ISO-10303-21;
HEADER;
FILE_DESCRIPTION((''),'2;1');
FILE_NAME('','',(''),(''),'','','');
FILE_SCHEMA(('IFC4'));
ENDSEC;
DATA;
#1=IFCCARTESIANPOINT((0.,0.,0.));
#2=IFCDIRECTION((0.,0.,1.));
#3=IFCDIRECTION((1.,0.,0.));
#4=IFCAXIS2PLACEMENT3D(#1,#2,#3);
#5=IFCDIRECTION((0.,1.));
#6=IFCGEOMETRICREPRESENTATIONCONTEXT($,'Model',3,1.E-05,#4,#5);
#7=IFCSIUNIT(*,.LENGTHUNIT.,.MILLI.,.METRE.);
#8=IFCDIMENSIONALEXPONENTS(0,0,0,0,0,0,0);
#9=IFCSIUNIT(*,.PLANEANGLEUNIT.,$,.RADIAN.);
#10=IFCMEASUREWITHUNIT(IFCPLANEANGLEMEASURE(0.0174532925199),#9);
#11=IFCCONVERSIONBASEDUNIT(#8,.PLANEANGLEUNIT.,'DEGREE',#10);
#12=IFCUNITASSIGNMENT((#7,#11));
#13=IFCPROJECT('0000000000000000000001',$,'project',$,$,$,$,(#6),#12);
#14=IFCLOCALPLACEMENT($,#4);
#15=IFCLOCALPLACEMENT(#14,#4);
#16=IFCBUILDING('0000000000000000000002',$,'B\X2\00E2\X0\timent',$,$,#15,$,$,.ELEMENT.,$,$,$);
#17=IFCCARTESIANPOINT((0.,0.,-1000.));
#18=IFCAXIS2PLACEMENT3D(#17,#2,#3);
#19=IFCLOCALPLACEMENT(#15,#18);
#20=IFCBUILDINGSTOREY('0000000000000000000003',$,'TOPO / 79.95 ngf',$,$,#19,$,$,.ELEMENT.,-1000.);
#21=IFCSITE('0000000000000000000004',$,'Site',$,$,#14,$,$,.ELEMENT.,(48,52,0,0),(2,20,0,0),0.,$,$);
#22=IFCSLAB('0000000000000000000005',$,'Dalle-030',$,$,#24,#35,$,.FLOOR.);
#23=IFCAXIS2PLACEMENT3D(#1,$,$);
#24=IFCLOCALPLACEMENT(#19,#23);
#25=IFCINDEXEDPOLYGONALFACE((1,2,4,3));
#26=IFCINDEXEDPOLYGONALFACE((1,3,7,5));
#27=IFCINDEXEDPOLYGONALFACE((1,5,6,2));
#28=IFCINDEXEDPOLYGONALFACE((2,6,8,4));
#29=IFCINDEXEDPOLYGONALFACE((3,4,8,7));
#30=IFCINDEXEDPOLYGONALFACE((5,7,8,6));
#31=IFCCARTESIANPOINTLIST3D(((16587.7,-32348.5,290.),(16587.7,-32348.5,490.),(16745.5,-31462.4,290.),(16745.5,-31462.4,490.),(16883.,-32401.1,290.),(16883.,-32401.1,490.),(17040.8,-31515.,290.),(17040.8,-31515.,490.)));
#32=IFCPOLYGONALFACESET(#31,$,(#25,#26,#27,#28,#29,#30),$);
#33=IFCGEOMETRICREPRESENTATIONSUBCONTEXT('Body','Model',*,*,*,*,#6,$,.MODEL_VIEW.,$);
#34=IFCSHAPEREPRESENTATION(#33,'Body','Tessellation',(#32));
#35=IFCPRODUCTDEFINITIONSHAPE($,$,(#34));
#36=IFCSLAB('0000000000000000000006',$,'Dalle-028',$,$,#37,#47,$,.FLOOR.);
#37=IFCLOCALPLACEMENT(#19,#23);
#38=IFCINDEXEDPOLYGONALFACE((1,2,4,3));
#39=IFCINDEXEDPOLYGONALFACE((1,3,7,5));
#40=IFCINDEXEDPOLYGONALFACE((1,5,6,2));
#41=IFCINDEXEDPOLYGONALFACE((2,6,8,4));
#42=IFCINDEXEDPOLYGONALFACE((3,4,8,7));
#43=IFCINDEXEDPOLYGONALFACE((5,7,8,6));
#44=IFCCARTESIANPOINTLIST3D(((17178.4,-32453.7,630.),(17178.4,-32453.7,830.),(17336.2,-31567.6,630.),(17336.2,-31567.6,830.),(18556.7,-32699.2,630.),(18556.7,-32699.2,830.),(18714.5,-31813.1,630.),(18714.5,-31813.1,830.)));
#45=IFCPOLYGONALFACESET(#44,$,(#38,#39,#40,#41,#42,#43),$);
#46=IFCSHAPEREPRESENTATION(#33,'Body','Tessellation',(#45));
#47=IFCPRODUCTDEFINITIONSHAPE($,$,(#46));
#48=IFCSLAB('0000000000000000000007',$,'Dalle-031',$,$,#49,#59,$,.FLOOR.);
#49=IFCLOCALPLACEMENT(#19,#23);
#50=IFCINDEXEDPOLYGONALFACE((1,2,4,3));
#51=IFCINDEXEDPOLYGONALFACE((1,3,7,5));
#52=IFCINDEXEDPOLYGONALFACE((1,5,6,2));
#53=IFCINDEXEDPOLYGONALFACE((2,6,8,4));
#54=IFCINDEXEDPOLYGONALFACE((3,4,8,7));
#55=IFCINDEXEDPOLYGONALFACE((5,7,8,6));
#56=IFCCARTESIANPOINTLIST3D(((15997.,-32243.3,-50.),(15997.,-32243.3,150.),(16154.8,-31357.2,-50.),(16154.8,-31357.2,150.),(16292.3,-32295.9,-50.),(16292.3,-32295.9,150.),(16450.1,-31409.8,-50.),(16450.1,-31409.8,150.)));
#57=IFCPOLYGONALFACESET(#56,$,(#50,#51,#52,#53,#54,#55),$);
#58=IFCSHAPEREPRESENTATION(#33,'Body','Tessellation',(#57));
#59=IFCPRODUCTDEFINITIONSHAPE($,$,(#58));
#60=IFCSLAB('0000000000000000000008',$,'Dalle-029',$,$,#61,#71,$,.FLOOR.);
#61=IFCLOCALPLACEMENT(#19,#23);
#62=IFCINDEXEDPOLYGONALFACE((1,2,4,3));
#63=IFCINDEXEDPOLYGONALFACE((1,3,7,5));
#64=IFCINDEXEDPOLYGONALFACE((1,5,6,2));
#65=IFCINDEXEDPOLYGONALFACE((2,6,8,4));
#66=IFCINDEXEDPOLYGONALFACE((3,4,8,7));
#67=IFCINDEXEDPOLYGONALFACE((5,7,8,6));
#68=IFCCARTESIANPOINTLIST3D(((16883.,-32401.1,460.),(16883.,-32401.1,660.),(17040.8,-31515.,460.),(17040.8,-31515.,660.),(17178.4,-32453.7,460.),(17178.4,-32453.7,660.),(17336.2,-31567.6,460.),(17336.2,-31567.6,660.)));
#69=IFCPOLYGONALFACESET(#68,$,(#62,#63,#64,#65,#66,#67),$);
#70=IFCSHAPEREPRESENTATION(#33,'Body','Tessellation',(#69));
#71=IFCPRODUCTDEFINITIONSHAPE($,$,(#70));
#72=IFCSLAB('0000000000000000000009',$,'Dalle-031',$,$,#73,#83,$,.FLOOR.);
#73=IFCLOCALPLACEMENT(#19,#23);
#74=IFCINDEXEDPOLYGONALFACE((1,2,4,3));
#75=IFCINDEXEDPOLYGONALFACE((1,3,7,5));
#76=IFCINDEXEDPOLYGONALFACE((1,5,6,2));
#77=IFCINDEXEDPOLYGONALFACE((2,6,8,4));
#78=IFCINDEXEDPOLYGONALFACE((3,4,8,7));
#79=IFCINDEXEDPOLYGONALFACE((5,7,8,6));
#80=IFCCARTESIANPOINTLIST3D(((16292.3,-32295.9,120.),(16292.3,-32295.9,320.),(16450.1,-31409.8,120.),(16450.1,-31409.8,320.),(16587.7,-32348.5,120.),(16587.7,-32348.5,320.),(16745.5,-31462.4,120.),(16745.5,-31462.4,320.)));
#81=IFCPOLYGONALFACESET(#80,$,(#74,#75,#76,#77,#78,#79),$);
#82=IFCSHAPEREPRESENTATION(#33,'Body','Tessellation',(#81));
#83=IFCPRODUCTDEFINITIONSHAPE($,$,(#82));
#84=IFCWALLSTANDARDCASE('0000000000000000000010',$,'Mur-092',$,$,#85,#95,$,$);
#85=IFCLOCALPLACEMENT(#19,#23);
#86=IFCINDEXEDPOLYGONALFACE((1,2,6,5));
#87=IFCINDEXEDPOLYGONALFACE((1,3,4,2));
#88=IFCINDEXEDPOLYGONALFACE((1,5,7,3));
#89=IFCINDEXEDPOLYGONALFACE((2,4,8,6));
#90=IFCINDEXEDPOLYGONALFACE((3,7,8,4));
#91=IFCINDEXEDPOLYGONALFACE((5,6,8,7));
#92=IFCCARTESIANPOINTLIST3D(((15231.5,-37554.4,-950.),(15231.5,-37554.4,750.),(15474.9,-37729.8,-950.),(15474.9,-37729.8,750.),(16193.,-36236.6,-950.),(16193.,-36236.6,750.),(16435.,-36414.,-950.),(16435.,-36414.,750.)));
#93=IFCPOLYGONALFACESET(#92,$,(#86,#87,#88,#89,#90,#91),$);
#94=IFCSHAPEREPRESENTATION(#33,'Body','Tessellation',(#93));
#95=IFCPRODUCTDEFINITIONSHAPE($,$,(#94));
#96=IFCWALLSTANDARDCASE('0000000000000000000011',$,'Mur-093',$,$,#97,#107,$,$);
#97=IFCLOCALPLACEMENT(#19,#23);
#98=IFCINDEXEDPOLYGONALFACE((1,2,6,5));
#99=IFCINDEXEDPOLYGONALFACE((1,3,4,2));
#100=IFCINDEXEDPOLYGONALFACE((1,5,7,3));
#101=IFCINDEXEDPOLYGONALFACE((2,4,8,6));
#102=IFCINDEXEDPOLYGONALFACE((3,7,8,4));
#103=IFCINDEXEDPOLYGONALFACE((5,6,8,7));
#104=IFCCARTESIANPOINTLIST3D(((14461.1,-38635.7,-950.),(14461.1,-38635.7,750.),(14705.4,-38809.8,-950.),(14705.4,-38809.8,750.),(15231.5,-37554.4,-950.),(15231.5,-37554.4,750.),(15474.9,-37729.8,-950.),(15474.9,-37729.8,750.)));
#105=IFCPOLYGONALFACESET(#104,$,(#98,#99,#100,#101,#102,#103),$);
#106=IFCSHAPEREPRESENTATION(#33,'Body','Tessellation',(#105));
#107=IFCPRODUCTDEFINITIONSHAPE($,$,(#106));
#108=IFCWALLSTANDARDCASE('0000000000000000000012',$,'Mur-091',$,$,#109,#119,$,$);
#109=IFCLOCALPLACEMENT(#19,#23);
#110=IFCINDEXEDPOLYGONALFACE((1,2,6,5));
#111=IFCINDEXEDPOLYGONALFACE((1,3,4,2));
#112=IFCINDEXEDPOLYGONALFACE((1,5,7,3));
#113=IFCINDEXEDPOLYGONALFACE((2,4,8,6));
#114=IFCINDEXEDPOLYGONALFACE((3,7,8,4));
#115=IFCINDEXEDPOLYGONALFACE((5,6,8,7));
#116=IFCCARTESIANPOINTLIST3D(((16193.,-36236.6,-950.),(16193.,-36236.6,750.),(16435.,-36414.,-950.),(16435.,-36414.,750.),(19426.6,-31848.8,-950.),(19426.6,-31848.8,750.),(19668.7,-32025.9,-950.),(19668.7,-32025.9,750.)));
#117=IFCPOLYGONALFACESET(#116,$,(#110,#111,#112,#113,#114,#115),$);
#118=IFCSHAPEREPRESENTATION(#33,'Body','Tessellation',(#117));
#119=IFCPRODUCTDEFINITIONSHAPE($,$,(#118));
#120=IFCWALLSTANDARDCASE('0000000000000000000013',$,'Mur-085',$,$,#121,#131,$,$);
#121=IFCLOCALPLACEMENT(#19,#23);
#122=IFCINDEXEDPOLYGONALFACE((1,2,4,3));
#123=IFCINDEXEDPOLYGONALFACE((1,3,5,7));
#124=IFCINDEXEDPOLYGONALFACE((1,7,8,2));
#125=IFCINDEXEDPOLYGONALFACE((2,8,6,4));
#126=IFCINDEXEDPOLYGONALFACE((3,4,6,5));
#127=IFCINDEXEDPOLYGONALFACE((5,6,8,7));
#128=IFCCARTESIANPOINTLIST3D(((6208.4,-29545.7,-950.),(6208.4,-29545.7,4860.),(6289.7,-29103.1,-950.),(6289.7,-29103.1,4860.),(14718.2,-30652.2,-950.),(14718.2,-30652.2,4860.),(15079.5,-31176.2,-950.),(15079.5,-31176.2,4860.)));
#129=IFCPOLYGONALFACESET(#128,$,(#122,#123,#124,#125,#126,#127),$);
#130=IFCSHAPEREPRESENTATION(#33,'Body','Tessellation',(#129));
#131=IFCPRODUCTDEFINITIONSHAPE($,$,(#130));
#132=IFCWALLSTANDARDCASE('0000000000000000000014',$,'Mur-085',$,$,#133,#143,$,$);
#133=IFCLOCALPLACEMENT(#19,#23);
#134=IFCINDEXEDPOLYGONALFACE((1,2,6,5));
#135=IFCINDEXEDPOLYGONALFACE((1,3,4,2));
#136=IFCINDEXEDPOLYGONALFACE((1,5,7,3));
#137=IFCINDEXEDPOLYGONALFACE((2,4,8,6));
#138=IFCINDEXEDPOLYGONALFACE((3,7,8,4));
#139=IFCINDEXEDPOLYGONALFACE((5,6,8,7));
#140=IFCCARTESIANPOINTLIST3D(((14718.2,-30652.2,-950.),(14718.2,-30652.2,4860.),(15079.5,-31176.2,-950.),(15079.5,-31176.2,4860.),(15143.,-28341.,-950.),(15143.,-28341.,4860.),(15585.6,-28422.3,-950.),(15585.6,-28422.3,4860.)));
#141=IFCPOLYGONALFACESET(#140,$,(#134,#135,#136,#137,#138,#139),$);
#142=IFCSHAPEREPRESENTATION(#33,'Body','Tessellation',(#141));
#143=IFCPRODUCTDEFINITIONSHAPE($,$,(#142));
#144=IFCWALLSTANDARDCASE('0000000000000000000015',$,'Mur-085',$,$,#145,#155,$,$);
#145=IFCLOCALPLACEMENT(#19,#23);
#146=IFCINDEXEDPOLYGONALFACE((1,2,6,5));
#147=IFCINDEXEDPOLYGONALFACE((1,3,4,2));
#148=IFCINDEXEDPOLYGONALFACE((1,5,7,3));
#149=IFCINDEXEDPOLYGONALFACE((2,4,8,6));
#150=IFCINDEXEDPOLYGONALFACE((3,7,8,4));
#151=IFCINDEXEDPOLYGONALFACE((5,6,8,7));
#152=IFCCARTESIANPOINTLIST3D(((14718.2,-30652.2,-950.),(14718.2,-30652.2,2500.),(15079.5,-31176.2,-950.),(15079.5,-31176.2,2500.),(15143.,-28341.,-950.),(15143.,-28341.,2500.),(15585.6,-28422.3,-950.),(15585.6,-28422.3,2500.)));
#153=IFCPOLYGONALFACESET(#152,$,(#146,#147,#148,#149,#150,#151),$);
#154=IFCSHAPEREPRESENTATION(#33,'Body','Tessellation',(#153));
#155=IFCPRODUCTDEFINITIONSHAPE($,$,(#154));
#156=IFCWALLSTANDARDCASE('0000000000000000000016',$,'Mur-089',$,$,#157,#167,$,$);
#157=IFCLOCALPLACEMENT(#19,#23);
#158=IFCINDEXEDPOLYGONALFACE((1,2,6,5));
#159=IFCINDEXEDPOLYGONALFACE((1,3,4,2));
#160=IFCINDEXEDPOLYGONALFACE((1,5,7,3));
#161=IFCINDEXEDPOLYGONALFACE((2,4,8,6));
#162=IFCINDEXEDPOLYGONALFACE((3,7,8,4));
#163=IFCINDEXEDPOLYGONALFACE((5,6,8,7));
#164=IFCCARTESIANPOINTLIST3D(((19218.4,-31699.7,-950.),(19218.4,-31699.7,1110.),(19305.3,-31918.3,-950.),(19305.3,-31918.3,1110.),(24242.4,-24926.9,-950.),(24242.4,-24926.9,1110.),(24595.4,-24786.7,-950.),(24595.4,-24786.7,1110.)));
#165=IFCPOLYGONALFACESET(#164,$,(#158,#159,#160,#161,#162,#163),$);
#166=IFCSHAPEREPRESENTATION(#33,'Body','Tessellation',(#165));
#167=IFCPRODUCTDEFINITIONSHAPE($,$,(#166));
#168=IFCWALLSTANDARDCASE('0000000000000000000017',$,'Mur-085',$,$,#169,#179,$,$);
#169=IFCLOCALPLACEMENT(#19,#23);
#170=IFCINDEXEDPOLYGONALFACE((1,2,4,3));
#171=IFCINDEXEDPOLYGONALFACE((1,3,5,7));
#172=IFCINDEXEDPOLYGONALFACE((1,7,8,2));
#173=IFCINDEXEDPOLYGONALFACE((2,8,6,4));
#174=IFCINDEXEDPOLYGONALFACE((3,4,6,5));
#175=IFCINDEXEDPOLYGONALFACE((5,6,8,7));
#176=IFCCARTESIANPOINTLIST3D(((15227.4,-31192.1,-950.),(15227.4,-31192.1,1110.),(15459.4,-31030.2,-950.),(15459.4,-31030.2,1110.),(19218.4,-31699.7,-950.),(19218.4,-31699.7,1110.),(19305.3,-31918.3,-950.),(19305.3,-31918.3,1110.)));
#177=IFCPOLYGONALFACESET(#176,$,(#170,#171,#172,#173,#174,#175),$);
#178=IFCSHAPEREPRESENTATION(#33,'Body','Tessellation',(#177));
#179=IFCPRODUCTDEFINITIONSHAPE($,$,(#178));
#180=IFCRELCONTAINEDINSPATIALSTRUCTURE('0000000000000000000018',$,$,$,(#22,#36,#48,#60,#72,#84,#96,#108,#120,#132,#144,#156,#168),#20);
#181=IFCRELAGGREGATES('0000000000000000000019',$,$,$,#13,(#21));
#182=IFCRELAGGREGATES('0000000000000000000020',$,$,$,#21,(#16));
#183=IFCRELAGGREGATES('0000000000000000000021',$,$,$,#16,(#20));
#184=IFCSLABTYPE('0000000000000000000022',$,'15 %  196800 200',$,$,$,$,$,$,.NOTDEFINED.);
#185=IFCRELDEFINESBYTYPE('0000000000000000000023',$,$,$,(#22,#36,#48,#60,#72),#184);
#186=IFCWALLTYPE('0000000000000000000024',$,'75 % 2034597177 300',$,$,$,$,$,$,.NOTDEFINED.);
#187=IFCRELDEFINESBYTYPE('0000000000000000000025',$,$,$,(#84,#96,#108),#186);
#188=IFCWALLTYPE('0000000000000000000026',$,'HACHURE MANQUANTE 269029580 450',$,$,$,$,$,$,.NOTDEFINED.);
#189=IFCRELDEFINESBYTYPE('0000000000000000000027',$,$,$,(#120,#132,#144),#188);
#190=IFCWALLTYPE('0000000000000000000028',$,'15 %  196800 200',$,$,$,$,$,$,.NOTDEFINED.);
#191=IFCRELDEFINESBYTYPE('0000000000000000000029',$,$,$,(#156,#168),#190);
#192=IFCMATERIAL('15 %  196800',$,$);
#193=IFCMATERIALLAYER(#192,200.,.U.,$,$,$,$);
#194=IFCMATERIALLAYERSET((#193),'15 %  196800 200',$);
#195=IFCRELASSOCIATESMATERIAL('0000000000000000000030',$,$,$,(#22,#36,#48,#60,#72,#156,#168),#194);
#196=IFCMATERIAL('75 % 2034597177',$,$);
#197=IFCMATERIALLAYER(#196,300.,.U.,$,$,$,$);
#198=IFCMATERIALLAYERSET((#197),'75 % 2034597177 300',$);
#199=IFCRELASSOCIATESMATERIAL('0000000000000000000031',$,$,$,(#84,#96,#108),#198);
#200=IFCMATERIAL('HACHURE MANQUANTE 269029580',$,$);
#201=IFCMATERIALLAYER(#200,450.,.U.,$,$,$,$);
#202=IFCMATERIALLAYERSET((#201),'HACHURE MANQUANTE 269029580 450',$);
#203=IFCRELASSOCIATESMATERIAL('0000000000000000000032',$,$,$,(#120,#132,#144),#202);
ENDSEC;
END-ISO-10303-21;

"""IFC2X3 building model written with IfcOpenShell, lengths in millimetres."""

from ifc_helpers import new_model, entity, si_unit, converted_unit, direction, frame, origin_with_axes, place, context, subcontext, project, spatial, polyline, outline, extrude, material, layer, layer_set, layer_usage, type_object, element, save


model = new_model("IFC2X3")

# Units and contexts
model_context = context("Model", 3, precision=1e-05, world=origin_with_axes(), true_north=direction((0.0, 1.0)))
body_context = subcontext(model_context, "Body", "Model", "MODEL_VIEW")
ifc_project = project(units=[si_unit("LENGTHUNIT", "METRE", prefix="MILLI"), converted_unit("PLANEANGLEUNIT", "DEGREE", entity("IfcPlaneAngleMeasure", 0.0174532925199), si_unit("PLANEANGLEUNIT", "RADIAN"), dimensions=[0, 0, 0, 0, 0, 0, 0])], contexts=[model_context])

# Site, building, storey
site_placement = place(None, origin_with_axes())
site = spatial("IfcSite", under=ifc_project, at=site_placement, Name="Site", CompositionType="ELEMENT", RefLatitude=(48, 52, 0, 0), RefLongitude=(2, 20, 0, 0), RefElevation=0.0)
building_placement = place(site_placement, origin_with_axes())
building = spatial("IfcBuilding", under=site, at=building_placement, Name="Bâtiment", CompositionType="ELEMENT")
storey_placement = place(building_placement, frame((0.0, 0.0, -1000.0), z_axis=(0.0, 0.0, 1.0), x_axis=(1.0, 0.0, 0.0)))
storey = spatial("IfcBuildingStorey", under=building, at=storey_placement, Name="TOPO / 79.95 ngf", CompositionType="ELEMENT", Elevation=-1000.0)

# Slabs
ifc_material_1 = material(Name="15 %  196800")
ifc_layer_1 = layer(ifc_material_1, 200.0, ventilated="UNKNOWN")
ifc_layer_set_1 = layer_set([ifc_layer_1], Name="15 %  196800 200")
ifc_layer_usage_1 = layer_usage(ifc_layer_set_1, "AXIS3", "NEGATIVE", 200.0)
slab_type_1 = type_object("IfcSlabType", Name="15 %  196800 200", PredefinedType="NOTDEFINED")
slab_1_placement = place(storey_placement, frame((16745.5, -31462.4, 490.0), z_axis=(0.0, 0.0, 1.0), x_axis=(1.0, 0.0, 0.0)))
element("IfcSlab", 1, at=slab_1_placement, inside=storey, type_object=slab_type_1, material=ifc_layer_usage_1, Name="Dalle-030", PredefinedType="FLOOR", context=body_context, shape_type="SweptSolid", body=[
    extrude(outline(polyline([(0.0, 0.0), (-157.8, -886.1), (137.5, -938.7), (295.4, -52.6), (0.0, 0.0)])), frame((0.0, 0.0, -200.0), z_axis=(0.0, 0.0, 1.0), x_axis=(1.0, 0.0, 0.0)), (0.0, 0.0, 1.0), 200.0),
])
ifc_layer_usage_2 = layer_usage(ifc_layer_set_1, "AXIS3", "NEGATIVE", 200.0)
slab_2_placement = place(storey_placement, frame((17336.2, -31567.6, 830.0), z_axis=(0.0, 0.0, 1.0), x_axis=(1.0, 0.0, 0.0)))
element("IfcSlab", 2, at=slab_2_placement, inside=storey, type_object=slab_type_1, material=ifc_layer_usage_2, Name="Dalle-028", PredefinedType="FLOOR", context=body_context, shape_type="SweptSolid", body=[
    extrude(outline(polyline([(0.0, 0.0), (-157.8, -886.1), (1220.5, -1131.6), (1378.3, -245.5), (0.0, 0.0)])), frame((0.0, 0.0, -200.0), z_axis=(0.0, 0.0, 1.0), x_axis=(1.0, 0.0, 0.0)), (0.0, 0.0, 1.0), 200.0),
])
ifc_layer_usage_3 = layer_usage(ifc_layer_set_1, "AXIS3", "NEGATIVE", 200.0)
slab_3_placement = place(storey_placement, frame((15997.0, -32243.3, 150.0), z_axis=(0.0, 0.0, 1.0), x_axis=(1.0, 0.0, 0.0)))
element("IfcSlab", 3, at=slab_3_placement, inside=storey, type_object=slab_type_1, material=ifc_layer_usage_3, Name="Dalle-031", PredefinedType="FLOOR", context=body_context, shape_type="SweptSolid", body=[
    extrude(outline(polyline([(0.0, 0.0), (295.4, -52.6), (453.2, 833.4), (157.8, 886.1), (0.0, 0.0)])), frame((0.0, 0.0, -200.0), z_axis=(0.0, 0.0, 1.0), x_axis=(1.0, 0.0, 0.0)), (0.0, 0.0, 1.0), 200.0),
])
ifc_layer_usage_4 = layer_usage(ifc_layer_set_1, "AXIS3", "NEGATIVE", 200.0)
slab_4_placement = place(storey_placement, frame((17040.8, -31515.0, 660.0), z_axis=(0.0, 0.0, 1.0), x_axis=(1.0, 0.0, 0.0)))
element("IfcSlab", 4, at=slab_4_placement, inside=storey, type_object=slab_type_1, material=ifc_layer_usage_4, Name="Dalle-029", PredefinedType="FLOOR", context=body_context, shape_type="SweptSolid", body=[
    extrude(outline(polyline([(0.0, 0.0), (-157.8, -886.1), (137.5, -938.7), (295.4, -52.6), (0.0, 0.0)])), frame((0.0, 0.0, -200.0), z_axis=(0.0, 0.0, 1.0), x_axis=(1.0, 0.0, 0.0)), (0.0, 0.0, 1.0), 200.0),
])
ifc_layer_usage_5 = layer_usage(ifc_layer_set_1, "AXIS3", "NEGATIVE", 200.0)
slab_5_placement = place(storey_placement, frame((16292.3, -32295.9, 320.0), z_axis=(0.0, 0.0, 1.0), x_axis=(1.0, 0.0, 0.0)))
element("IfcSlab", 5, at=slab_5_placement, inside=storey, type_object=slab_type_1, material=ifc_layer_usage_5, Name="Dalle-031", PredefinedType="FLOOR", context=body_context, shape_type="SweptSolid", body=[
    extrude(outline(polyline([(0.0, 0.0), (295.4, -52.6), (453.2, 833.4), (157.8, 886.1), (0.0, 0.0)])), frame((0.0, 0.0, -200.0), z_axis=(0.0, 0.0, 1.0), x_axis=(1.0, 0.0, 0.0)), (0.0, 0.0, 1.0), 200.0),
])

# Walls
ifc_material_2 = material(Name="75 % 2034597177")
ifc_layer_2 = layer(ifc_material_2, 300.0, ventilated="UNKNOWN")
ifc_layer_set_2 = layer_set([ifc_layer_2], Name="75 % 2034597177 300")
ifc_layer_usage_6 = layer_usage(ifc_layer_set_2, "AXIS2", "NEGATIVE", 300.0)
wall_type_1 = type_object("IfcWallType", Name="75 % 2034597177 300", PredefinedType="NOTDEFINED")
wall_1_placement = place(storey_placement, frame((16193.0, -36236.6, -950.0), z_axis=(0.0, 0.0, 1.0), x_axis=(-0.589442, -0.807811, 0.0)))
element("IfcWallStandardCase", 6, at=wall_1_placement, inside=storey, type_object=wall_type_1, material=ifc_layer_usage_6, Name="Mur-092", context=body_context, shape_type="SweptSolid", body=[
    extrude(outline(polyline([(0.0, 0.0), (1631.2, 0.0), (1629.5, 300.0), (0.7, 300.0), (0.0, 0.0)])), origin_with_axes(), (0.0, 0.0, 1.0), 1700.0),
])
ifc_layer_usage_7 = layer_usage(ifc_layer_set_2, "AXIS2", "NEGATIVE", 300.0)
wall_2_placement = place(storey_placement, frame((15231.5, -37554.4, -950.0), z_axis=(0.0, 0.0, 1.0), x_axis=(-0.580268, -0.814426, 0.0)))
element("IfcWallStandardCase", 7, at=wall_2_placement, inside=storey, type_object=wall_type_1, material=ifc_layer_usage_7, Name="Mur-093", context=body_context, shape_type="SweptSolid", body=[
    extrude(outline(polyline([(0.0, 0.0), (1327.7, 0.0), (1327.7, 300.0), (1.7, 300.0), (0.0, 0.0)])), origin_with_axes(), (0.0, 0.0, 1.0), 1700.0),
])
ifc_layer_usage_8 = layer_usage(ifc_layer_set_2, "AXIS2", "NEGATIVE", 300.0)
wall_3_placement = place(storey_placement, frame((19426.6, -31848.8, -950.0), z_axis=(0.0, 0.0, 1.0), x_axis=(-0.593247, -0.805021, 0.0)))
element("IfcWallStandardCase", 8, at=wall_3_placement, inside=storey, type_object=wall_type_1, material=ifc_layer_usage_8, Name="Mur-091", context=body_context, shape_type="SweptSolid", body=[
    extrude(outline(polyline([(0.0, 0.0), (5450.6, 0.0), (5449.9, 300.0), (-1.0, 300.0), (0.0, 0.0)])), origin_with_axes(), (0.0, 0.0, 1.0), 1700.0),
])
ifc_material_3 = material(Name="HACHURE MANQUANTE 269029580")
ifc_layer_3 = layer(ifc_material_3, 450.0, ventilated="UNKNOWN")
ifc_layer_set_3 = layer_set([ifc_layer_3], Name="HACHURE MANQUANTE 269029580 450")
ifc_layer_usage_9 = layer_usage(ifc_layer_set_3, "AXIS2", "NEGATIVE", 450.0)
wall_type_2 = type_object("IfcWallType", Name="HACHURE MANQUANTE 269029580 450", PredefinedType="NOTDEFINED")
wall_4_placement = place(storey_placement, frame((6208.4, -29545.7, -950.0), z_axis=(0.0, 0.0, 1.0), x_axis=(0.983526, -0.180766, 0.0)))
element("IfcWallStandardCase", 9, at=wall_4_placement, inside=storey, type_object=wall_type_2, material=ifc_layer_usage_9, Name="Mur-085", context=body_context, shape_type="SweptSolid", body=[
    extrude(outline(polyline([(0.0, 0.0), (9019.7, 0.0), (8569.7, 450.0), (0.0, 450.0), (0.0, 0.0)])), origin_with_axes(), (0.0, 0.0, 1.0), 5810.0),
])
ifc_layer_usage_10 = layer_usage(ifc_layer_set_3, "AXIS2", "NEGATIVE", 450.0)
wall_5_placement = place(storey_placement, frame((15079.5, -31176.2, -950.0), z_axis=(0.0, 0.0, 1.0), x_axis=(0.180766, 0.983526, 0.0)))
element("IfcWallStandardCase", 10, at=wall_5_placement, inside=storey, type_object=wall_type_2, material=ifc_layer_usage_10, Name="Mur-085", context=body_context, shape_type="SweptSolid", body=[
    extrude(outline(polyline([(0.0, 0.0), (2800.0, 0.0), (2800.0, 450.0), (450.0, 450.0), (0.0, 0.0)])), origin_with_axes(), (0.0, 0.0, 1.0), 5810.0),
])
ifc_layer_usage_11 = layer_usage(ifc_layer_set_3, "AXIS2", "NEGATIVE", 450.0)
wall_6_placement = place(storey_placement, frame((15079.5, -31176.2, -950.0), z_axis=(0.0, 0.0, 1.0), x_axis=(0.180766, 0.983526, 0.0)))
element("IfcWallStandardCase", 11, at=wall_6_placement, inside=storey, type_object=wall_type_2, material=ifc_layer_usage_11, Name="Mur-085", context=body_context, shape_type="SweptSolid", body=[
    extrude(outline(polyline([(0.0, 0.0), (2800.0, 0.0), (2800.0, 450.0), (450.0, 450.0), (0.0, 0.0)])), origin_with_axes(), (0.0, 0.0, 1.0), 3450.0),
])
ifc_layer_usage_12 = layer_usage(ifc_layer_set_1, "AXIS2", "POSITIVE", -200.0)
wall_type_3 = type_object("IfcWallType", Name="15 %  196800 200", PredefinedType="NOTDEFINED")
wall_7_placement = place(storey_placement, frame((19218.4, -31699.7, -950.0), z_axis=(0.0, 0.0, 1.0), x_axis=(0.59577, 0.803155, 0.0)))
element("IfcWallStandardCase", 12, at=wall_7_placement, inside=storey, type_object=wall_type_3, material=ifc_layer_usage_12, Name="Mur-089", context=body_context, shape_type="SweptSolid", body=[
    extrude(outline(polyline([(-123.8, -200.0), (8755.6, -200.0), (8432.7, 0.0), (0.0, 0.0), (-123.8, -200.0)])), origin_with_axes(), (0.0, 0.0, 1.0), 2060.0),
])
ifc_layer_usage_13 = layer_usage(ifc_layer_set_1, "AXIS2", "POSITIVE", -200.0)
wall_8_placement = place(storey_placement, frame((15459.4, -31030.2, -950.0), z_axis=(0.0, 0.0, 1.0), x_axis=(0.984508, -0.175339, 0.0)))
element("IfcWallStandardCase", 13, at=wall_8_placement, inside=storey, type_object=wall_type_3, material=ifc_layer_usage_13, Name="Mur-085", context=body_context, shape_type="SweptSolid", body=[
    extrude(outline(polyline([(-200.0, -200.0), (3942.0, -200.0), (3818.1, 0.0), (0.0, 0.0), (-200.0, -200.0)])), origin_with_axes(), (0.0, 0.0, 1.0), 2060.0),
])

save(model, "model.ifc")
